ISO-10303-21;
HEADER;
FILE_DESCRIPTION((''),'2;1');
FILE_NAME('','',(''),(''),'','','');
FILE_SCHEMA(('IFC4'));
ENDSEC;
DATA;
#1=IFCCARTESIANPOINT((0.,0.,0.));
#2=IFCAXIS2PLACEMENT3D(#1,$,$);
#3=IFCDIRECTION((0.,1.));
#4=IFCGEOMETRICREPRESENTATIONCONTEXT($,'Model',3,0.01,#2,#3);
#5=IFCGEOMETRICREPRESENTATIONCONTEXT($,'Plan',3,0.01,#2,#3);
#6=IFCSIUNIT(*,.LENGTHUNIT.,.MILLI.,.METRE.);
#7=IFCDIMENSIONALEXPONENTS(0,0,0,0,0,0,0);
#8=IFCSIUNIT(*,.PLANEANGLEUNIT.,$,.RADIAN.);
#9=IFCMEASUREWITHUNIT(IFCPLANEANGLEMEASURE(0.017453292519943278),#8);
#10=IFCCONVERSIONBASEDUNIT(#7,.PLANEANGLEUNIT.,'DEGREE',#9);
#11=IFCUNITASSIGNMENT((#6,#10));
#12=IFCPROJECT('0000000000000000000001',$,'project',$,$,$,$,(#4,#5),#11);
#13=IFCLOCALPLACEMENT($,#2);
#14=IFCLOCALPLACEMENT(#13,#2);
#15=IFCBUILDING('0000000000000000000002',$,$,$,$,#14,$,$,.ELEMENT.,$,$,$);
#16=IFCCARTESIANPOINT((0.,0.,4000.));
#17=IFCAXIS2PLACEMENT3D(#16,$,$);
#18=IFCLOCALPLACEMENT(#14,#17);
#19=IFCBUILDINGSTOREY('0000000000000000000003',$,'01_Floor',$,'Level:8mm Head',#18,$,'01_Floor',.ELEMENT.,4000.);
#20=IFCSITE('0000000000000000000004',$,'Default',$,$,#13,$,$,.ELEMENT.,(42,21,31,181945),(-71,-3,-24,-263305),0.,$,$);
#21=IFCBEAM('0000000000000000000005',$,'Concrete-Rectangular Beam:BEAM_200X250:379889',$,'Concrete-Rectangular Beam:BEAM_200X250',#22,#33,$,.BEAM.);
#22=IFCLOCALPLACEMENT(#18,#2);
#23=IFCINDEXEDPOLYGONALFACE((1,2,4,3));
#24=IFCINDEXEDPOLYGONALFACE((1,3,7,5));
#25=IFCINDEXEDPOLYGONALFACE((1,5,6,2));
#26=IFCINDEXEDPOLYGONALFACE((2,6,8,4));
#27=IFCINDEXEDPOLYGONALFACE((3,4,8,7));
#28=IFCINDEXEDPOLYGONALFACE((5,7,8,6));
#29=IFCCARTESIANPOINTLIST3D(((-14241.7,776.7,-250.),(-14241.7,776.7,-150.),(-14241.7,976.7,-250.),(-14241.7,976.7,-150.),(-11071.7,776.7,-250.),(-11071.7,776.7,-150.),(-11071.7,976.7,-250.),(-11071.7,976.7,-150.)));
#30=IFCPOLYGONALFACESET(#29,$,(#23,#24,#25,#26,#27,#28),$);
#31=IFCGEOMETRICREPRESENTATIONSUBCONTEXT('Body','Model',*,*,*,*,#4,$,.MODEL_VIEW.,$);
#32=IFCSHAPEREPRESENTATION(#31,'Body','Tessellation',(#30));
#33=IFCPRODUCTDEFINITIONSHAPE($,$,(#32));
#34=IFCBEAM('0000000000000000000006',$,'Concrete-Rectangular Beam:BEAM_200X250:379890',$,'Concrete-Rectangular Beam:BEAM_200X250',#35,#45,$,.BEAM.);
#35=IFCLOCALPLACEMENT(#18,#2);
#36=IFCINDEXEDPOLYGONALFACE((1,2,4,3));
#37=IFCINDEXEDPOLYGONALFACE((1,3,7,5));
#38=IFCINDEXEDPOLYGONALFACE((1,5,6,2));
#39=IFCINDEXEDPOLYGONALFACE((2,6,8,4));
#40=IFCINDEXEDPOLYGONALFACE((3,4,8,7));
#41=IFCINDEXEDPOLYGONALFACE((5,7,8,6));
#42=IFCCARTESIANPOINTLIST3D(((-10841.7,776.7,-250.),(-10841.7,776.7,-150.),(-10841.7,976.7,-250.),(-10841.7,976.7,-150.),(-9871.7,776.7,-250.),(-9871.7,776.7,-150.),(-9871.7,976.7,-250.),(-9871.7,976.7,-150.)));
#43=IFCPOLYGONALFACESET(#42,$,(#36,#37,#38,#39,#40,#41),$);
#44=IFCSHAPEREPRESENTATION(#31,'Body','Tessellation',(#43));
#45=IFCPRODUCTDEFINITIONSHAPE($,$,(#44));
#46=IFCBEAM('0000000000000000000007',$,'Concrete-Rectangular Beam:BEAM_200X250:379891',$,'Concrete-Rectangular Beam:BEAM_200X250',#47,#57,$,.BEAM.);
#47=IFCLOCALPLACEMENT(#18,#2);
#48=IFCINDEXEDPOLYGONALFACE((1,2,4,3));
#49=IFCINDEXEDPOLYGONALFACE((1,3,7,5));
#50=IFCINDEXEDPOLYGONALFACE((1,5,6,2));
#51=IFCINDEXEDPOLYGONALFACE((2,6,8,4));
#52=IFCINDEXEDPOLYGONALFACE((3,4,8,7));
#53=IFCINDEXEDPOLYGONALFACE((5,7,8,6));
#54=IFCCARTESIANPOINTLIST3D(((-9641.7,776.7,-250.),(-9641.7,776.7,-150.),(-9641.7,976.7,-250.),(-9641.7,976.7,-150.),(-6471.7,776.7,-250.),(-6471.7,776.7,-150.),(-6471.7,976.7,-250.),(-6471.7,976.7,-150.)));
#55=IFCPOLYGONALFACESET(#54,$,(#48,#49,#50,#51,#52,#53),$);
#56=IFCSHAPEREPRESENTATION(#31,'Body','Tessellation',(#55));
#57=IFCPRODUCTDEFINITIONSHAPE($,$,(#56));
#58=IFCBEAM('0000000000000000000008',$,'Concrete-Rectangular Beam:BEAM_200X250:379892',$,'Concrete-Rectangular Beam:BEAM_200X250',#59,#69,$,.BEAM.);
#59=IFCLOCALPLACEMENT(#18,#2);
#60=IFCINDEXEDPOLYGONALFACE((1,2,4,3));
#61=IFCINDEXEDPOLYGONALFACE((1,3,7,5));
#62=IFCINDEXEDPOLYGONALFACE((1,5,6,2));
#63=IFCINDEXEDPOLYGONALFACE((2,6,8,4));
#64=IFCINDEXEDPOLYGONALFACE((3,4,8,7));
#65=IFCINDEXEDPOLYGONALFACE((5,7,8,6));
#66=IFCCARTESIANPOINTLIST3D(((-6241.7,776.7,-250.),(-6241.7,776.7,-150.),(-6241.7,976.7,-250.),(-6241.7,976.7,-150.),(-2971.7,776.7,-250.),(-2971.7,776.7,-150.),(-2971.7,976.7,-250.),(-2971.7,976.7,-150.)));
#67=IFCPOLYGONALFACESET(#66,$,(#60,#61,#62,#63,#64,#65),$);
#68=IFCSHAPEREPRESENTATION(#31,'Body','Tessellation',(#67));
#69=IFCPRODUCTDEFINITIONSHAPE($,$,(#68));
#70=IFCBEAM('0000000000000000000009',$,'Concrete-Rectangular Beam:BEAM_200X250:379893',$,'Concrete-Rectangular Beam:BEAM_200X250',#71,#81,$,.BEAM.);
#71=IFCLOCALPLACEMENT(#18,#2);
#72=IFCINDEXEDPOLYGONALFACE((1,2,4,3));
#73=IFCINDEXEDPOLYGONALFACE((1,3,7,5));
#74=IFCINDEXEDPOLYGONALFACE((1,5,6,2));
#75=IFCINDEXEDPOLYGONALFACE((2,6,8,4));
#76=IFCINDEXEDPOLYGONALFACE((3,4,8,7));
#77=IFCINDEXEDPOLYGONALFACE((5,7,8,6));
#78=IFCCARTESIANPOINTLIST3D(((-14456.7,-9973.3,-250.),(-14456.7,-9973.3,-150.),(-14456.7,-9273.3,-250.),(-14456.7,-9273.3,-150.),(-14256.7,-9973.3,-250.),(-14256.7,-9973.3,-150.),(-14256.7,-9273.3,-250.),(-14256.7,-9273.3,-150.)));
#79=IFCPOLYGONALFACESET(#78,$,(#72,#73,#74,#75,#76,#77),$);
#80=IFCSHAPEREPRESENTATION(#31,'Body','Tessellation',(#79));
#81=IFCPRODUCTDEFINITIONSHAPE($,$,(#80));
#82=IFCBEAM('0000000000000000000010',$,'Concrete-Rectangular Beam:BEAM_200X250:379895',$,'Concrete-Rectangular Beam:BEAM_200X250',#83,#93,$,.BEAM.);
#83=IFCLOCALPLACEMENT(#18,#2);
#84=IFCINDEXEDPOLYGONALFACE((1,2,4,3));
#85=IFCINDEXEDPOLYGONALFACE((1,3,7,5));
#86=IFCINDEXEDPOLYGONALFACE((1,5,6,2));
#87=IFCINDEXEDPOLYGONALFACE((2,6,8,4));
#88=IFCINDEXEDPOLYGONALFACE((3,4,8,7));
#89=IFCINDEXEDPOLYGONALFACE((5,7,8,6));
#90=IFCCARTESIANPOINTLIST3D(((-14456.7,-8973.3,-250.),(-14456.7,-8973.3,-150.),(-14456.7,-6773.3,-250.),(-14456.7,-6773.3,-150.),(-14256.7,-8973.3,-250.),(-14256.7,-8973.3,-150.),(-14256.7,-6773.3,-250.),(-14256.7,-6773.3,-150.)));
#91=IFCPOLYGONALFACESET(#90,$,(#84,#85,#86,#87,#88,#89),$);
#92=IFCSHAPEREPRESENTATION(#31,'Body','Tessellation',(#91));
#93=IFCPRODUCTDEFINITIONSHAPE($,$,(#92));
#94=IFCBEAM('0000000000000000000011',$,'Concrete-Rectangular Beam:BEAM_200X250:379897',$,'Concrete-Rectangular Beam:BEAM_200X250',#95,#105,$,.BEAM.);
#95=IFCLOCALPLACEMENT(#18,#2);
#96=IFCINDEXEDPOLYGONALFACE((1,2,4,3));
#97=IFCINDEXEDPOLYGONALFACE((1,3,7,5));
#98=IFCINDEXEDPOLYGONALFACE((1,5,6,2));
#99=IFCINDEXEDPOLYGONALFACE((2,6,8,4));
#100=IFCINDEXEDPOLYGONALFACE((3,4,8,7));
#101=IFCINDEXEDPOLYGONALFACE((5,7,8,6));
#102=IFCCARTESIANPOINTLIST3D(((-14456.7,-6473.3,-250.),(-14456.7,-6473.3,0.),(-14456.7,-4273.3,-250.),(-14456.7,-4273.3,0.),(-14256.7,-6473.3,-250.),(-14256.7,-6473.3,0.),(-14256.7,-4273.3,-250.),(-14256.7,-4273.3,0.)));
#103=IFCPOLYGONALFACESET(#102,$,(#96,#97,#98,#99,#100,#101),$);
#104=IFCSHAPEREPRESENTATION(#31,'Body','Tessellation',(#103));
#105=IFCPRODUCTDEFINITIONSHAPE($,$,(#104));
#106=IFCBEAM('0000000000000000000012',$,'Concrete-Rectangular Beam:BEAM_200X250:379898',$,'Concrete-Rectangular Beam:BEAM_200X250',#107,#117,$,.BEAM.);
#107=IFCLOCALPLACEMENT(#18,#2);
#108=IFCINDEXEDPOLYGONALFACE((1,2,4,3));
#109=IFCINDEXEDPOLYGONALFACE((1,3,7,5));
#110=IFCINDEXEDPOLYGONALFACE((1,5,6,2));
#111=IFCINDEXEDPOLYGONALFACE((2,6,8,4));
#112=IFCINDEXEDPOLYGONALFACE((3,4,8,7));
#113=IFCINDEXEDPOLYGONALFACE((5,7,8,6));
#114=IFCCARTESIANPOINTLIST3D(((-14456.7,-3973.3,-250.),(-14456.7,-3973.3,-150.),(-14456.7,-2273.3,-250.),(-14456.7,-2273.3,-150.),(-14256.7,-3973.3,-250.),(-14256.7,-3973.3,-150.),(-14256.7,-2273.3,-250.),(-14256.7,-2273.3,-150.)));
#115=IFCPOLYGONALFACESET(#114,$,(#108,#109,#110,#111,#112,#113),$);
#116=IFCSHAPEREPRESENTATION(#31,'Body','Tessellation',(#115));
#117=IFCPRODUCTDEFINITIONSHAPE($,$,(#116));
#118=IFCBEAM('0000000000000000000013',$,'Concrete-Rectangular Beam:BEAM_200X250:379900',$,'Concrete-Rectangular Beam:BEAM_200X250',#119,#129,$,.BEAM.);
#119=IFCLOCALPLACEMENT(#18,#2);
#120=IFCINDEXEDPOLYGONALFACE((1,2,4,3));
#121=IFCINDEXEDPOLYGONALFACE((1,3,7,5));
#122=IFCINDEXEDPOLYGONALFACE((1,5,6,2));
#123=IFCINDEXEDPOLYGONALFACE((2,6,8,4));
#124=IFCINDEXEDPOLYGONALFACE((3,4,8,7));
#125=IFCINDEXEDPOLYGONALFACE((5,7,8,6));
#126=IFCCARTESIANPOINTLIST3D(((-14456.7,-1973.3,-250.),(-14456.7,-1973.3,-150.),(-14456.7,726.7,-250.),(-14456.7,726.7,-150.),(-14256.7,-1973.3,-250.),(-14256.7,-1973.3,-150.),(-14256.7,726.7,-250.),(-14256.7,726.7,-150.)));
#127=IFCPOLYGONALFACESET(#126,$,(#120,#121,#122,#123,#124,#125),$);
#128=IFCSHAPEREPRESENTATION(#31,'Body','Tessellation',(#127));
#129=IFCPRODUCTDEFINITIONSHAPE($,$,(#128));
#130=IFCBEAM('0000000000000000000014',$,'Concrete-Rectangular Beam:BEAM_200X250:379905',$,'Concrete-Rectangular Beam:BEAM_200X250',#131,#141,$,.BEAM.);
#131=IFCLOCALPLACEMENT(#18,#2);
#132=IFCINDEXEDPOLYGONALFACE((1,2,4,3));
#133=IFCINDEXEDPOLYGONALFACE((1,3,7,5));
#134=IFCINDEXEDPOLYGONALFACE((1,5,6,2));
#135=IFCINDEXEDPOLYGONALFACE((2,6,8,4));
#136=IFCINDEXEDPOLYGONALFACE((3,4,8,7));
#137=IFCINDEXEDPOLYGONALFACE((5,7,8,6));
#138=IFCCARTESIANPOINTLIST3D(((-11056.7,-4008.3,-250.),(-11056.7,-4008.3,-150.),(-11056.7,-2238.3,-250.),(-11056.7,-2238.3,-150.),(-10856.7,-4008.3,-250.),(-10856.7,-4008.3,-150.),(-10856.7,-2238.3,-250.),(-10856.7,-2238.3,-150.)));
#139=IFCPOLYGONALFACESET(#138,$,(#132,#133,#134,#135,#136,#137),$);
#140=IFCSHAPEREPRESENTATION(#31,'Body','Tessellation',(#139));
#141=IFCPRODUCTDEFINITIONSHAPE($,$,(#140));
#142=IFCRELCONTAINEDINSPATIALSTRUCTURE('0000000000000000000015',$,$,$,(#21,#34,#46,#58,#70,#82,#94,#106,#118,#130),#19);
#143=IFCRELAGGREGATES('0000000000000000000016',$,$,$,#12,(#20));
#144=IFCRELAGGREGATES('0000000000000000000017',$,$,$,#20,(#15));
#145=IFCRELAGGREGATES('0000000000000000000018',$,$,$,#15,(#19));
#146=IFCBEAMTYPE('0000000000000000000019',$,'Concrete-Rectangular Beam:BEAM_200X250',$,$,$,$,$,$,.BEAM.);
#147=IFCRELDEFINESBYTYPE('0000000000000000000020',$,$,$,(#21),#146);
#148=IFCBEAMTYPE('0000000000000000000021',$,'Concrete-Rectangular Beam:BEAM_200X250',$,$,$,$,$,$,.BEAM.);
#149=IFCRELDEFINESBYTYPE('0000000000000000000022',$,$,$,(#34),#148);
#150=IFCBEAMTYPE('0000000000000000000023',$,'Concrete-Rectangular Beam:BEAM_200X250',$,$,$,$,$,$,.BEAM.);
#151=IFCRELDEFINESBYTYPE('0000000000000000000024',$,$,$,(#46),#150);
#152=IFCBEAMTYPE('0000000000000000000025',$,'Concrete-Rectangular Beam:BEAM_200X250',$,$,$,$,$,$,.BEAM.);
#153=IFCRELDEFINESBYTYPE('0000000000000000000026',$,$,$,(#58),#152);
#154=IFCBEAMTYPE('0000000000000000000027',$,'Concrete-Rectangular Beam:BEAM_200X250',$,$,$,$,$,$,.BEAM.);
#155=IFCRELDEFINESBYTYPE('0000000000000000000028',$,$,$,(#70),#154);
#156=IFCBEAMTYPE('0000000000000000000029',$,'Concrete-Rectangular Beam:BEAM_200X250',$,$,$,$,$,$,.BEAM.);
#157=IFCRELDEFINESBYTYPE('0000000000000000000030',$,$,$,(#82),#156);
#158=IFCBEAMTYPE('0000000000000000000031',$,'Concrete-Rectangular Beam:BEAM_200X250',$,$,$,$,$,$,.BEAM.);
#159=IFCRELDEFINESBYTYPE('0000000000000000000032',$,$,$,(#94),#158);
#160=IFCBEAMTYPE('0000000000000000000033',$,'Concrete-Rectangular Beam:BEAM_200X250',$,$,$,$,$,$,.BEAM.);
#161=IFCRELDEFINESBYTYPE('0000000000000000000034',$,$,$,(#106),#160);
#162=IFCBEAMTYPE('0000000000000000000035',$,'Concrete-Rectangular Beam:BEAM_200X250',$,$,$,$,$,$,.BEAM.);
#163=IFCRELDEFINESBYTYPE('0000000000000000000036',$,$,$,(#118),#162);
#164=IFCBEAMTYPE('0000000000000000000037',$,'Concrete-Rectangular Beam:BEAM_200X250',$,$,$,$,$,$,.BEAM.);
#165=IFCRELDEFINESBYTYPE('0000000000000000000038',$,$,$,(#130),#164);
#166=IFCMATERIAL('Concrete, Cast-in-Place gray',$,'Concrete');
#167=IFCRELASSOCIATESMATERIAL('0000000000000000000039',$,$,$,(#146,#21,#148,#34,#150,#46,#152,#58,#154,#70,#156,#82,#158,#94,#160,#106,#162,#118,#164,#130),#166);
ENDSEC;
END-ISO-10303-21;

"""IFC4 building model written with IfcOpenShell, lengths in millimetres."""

from ifc_helpers import new_model, entity, si_unit, converted_unit, direction, frame, origin, place, context, subcontext, project, spatial, indexed_curve, outline, extrude, source, transform, mapped, material, type_object, type_shapes, element, save


model = new_model("IFC4")

# Units and contexts
model_context = context("Model", 3, precision=0.01, world=origin(), true_north=direction((0.0, 1.0)))
plan_context = context("Plan", 3, precision=0.01, world=origin(), true_north=direction((0.0, 1.0)))
body_context = subcontext(model_context, "Body", "Model", "MODEL_VIEW")
ifc_project = project(units=[si_unit("LENGTHUNIT", "METRE", prefix="MILLI"), converted_unit("PLANEANGLEUNIT", "DEGREE", entity("IfcPlaneAngleMeasure", 0.017453292519943278), si_unit("PLANEANGLEUNIT", "RADIAN"), dimensions=[0, 0, 0, 0, 0, 0, 0])], contexts=[model_context, plan_context])

# Site, building, storey
site_placement = place(None, origin())
site = spatial("IfcSite", under=ifc_project, at=site_placement, Name="Default", CompositionType="ELEMENT", RefLatitude=(42, 21, 31, 181945), RefLongitude=(-71, -3, -24, -263305), RefElevation=0.0)
building_placement = place(site_placement, origin())
building = spatial("IfcBuilding", under=site, at=building_placement, CompositionType="ELEMENT")
storey_placement = place(building_placement, frame((0.0, 0.0, 4000.0)))
storey = spatial("IfcBuildingStorey", under=building, at=storey_placement, Name="01_Floor", ObjectType="Level:8mm Head", LongName="01_Floor", CompositionType="ELEMENT", Elevation=4000.0)

# Beams
ifc_material = material(Name="Concrete, Cast-in-Place gray", Category="Concrete")
beam_type_1 = type_object("IfcBeamType", Name="Concrete-Rectangular Beam:BEAM_200X250", PredefinedType="BEAM", material=ifc_material)
shared_shape_1 = source(origin(), body_context, "Body", "SweptSolid", [
    extrude(outline(indexed_curve([(-50.0, -100.0), (50.0, -100.0), (50.0, 100.0), (-50.0, 100.0), (-50.0, -100.0)], self_intersect=False)), frame((-14241.7, 876.7, 3800.0), z_axis=(1.0, 0.0, 0.0), x_axis=(0.0, 0.0, -1.0)), (0.0, 0.0, 1.0), 3170.0),
])
type_shapes(beam_type_1, [shared_shape_1])
beam_1_placement = place(storey_placement, frame((0.0, 0.0, -4000.0)))
element("IfcBeam", 1, at=beam_1_placement, inside=storey, type_object=beam_type_1, material=ifc_material, Name="Concrete-Rectangular Beam:BEAM_200X250:379889", ObjectType="Concrete-Rectangular Beam:BEAM_200X250", PredefinedType="BEAM", context=body_context, shape_type="MappedRepresentation", body=[
    mapped(shared_shape_1, transform((0.0, 0.0, 0.0), scale=1.0)),
])
beam_type_2 = type_object("IfcBeamType", Name="Concrete-Rectangular Beam:BEAM_200X250", PredefinedType="BEAM", material=ifc_material)
shared_shape_2 = source(origin(), body_context, "Body", "SweptSolid", [
    extrude(outline(indexed_curve([(-50.0, -100.0), (50.0, -100.0), (50.0, 100.0), (-50.0, 100.0), (-50.0, -100.0)], self_intersect=False)), frame((-10841.7, 876.7, 3800.0), z_axis=(1.0, 0.0, 0.0), x_axis=(0.0, 0.0, -1.0)), (0.0, 0.0, 1.0), 970.0),
])
type_shapes(beam_type_2, [shared_shape_2])
beam_2_placement = place(storey_placement, frame((0.0, 0.0, -4000.0)))
element("IfcBeam", 2, at=beam_2_placement, inside=storey, type_object=beam_type_2, material=ifc_material, Name="Concrete-Rectangular Beam:BEAM_200X250:379890", ObjectType="Concrete-Rectangular Beam:BEAM_200X250", PredefinedType="BEAM", context=body_context, shape_type="MappedRepresentation", body=[
    mapped(shared_shape_2, transform((0.0, 0.0, 0.0), scale=1.0)),
])
beam_type_3 = type_object("IfcBeamType", Name="Concrete-Rectangular Beam:BEAM_200X250", PredefinedType="BEAM", material=ifc_material)
shared_shape_3 = source(origin(), body_context, "Body", "SweptSolid", [
    extrude(outline(indexed_curve([(-50.0, -100.0), (50.0, -100.0), (50.0, 100.0), (-50.0, 100.0), (-50.0, -100.0)], self_intersect=False)), frame((-9641.7, 876.7, 3800.0), z_axis=(1.0, 0.0, 0.0), x_axis=(0.0, 0.0, -1.0)), (0.0, 0.0, 1.0), 3170.0),
])
type_shapes(beam_type_3, [shared_shape_3])
beam_3_placement = place(storey_placement, frame((0.0, 0.0, -4000.0)))
element("IfcBeam", 3, at=beam_3_placement, inside=storey, type_object=beam_type_3, material=ifc_material, Name="Concrete-Rectangular Beam:BEAM_200X250:379891", ObjectType="Concrete-Rectangular Beam:BEAM_200X250", PredefinedType="BEAM", context=body_context, shape_type="MappedRepresentation", body=[
    mapped(shared_shape_3, transform((0.0, 0.0, 0.0), scale=1.0)),
])
beam_type_4 = type_object("IfcBeamType", Name="Concrete-Rectangular Beam:BEAM_200X250", PredefinedType="BEAM", material=ifc_material)
shared_shape_4 = source(origin(), body_context, "Body", "SweptSolid", [
    extrude(outline(indexed_curve([(-50.0, -100.0), (50.0, -100.0), (50.0, 100.0), (-50.0, 100.0), (-50.0, -100.0)], self_intersect=False)), frame((-6241.7, 876.7, 3800.0), z_axis=(1.0, 0.0, 0.0), x_axis=(0.0, 0.0, -1.0)), (0.0, 0.0, 1.0), 3270.0),
])
type_shapes(beam_type_4, [shared_shape_4])
beam_4_placement = place(storey_placement, frame((0.0, 0.0, -4000.0)))
element("IfcBeam", 4, at=beam_4_placement, inside=storey, type_object=beam_type_4, material=ifc_material, Name="Concrete-Rectangular Beam:BEAM_200X250:379892", ObjectType="Concrete-Rectangular Beam:BEAM_200X250", PredefinedType="BEAM", context=body_context, shape_type="MappedRepresentation", body=[
    mapped(shared_shape_4, transform((0.0, 0.0, 0.0), scale=1.0)),
])
beam_type_5 = type_object("IfcBeamType", Name="Concrete-Rectangular Beam:BEAM_200X250", PredefinedType="BEAM", material=ifc_material)
shared_shape_5 = source(origin(), body_context, "Body", "SweptSolid", [
    extrude(outline(indexed_curve([(-100.0, -50.0), (100.0, -50.0), (100.0, 50.0), (-100.0, 50.0), (-100.0, -50.0)], self_intersect=False)), frame((-14356.7, -9973.3, 3800.0), z_axis=(0.0, 1.0, 0.0), x_axis=(-1.0, 0.0, 0.0)), (0.0, 0.0, 1.0), 700.0),
])
type_shapes(beam_type_5, [shared_shape_5])
beam_5_placement = place(storey_placement, frame((0.0, 0.0, -4000.0)))
element("IfcBeam", 5, at=beam_5_placement, inside=storey, type_object=beam_type_5, material=ifc_material, Name="Concrete-Rectangular Beam:BEAM_200X250:379893", ObjectType="Concrete-Rectangular Beam:BEAM_200X250", PredefinedType="BEAM", context=body_context, shape_type="MappedRepresentation", body=[
    mapped(shared_shape_5, transform((0.0, 0.0, 0.0), scale=1.0)),
])
beam_type_6 = type_object("IfcBeamType", Name="Concrete-Rectangular Beam:BEAM_200X250", PredefinedType="BEAM", material=ifc_material)
shared_shape_6 = source(origin(), body_context, "Body", "SweptSolid", [
    extrude(outline(indexed_curve([(-100.0, -50.0), (100.0, -50.0), (100.0, 50.0), (-100.0, 50.0), (-100.0, -50.0)], self_intersect=False)), frame((-14356.7, -8973.3, 3800.0), z_axis=(0.0, 1.0, 0.0), x_axis=(-1.0, 0.0, 0.0)), (0.0, 0.0, 1.0), 2200.0),
])
type_shapes(beam_type_6, [shared_shape_6])
beam_6_placement = place(storey_placement, frame((0.0, 0.0, -4000.0)))
element("IfcBeam", 6, at=beam_6_placement, inside=storey, type_object=beam_type_6, material=ifc_material, Name="Concrete-Rectangular Beam:BEAM_200X250:379895", ObjectType="Concrete-Rectangular Beam:BEAM_200X250", PredefinedType="BEAM", context=body_context, shape_type="MappedRepresentation", body=[
    mapped(shared_shape_6, transform((0.0, 0.0, 0.0), scale=1.0)),
])
beam_type_7 = type_object("IfcBeamType", Name="Concrete-Rectangular Beam:BEAM_200X250", PredefinedType="BEAM", material=ifc_material)
shared_shape_7 = source(origin(), body_context, "Body", "SweptSolid", [
    extrude(outline(indexed_curve([(-100.0, -125.0), (100.0, -125.0), (100.0, 125.0), (-100.0, 125.0), (-100.0, -125.0)], self_intersect=False)), frame((-14356.7, -6473.3, 3875.0), z_axis=(0.0, 1.0, 0.0), x_axis=(-1.0, 0.0, 0.0)), (0.0, 0.0, 1.0), 2200.0),
])
type_shapes(beam_type_7, [shared_shape_7])
beam_7_placement = place(storey_placement, frame((0.0, 0.0, -4000.0)))
element("IfcBeam", 7, at=beam_7_placement, inside=storey, type_object=beam_type_7, material=ifc_material, Name="Concrete-Rectangular Beam:BEAM_200X250:379897", ObjectType="Concrete-Rectangular Beam:BEAM_200X250", PredefinedType="BEAM", context=body_context, shape_type="MappedRepresentation", body=[
    mapped(shared_shape_7, transform((0.0, 0.0, 0.0), scale=1.0)),
])
beam_type_8 = type_object("IfcBeamType", Name="Concrete-Rectangular Beam:BEAM_200X250", PredefinedType="BEAM", material=ifc_material)
shared_shape_8 = source(origin(), body_context, "Body", "SweptSolid", [
    extrude(outline(indexed_curve([(-100.0, -50.0), (100.0, -50.0), (100.0, 50.0), (-100.0, 50.0), (-100.0, -50.0)], self_intersect=False)), frame((-14356.7, -3973.3, 3800.0), z_axis=(0.0, 1.0, 0.0), x_axis=(-1.0, 0.0, 0.0)), (0.0, 0.0, 1.0), 1700.0),
])
type_shapes(beam_type_8, [shared_shape_8])
beam_8_placement = place(storey_placement, frame((0.0, 0.0, -4000.0)))
element("IfcBeam", 8, at=beam_8_placement, inside=storey, type_object=beam_type_8, material=ifc_material, Name="Concrete-Rectangular Beam:BEAM_200X250:379898", ObjectType="Concrete-Rectangular Beam:BEAM_200X250", PredefinedType="BEAM", context=body_context, shape_type="MappedRepresentation", body=[
    mapped(shared_shape_8, transform((0.0, 0.0, 0.0), scale=1.0)),
])
beam_type_9 = type_object("IfcBeamType", Name="Concrete-Rectangular Beam:BEAM_200X250", PredefinedType="BEAM", material=ifc_material)
shared_shape_9 = source(origin(), body_context, "Body", "SweptSolid", [
    extrude(outline(indexed_curve([(-100.0, -50.0), (100.0, -50.0), (100.0, 50.0), (-100.0, 50.0), (-100.0, -50.0)], self_intersect=False)), frame((-14356.7, -1973.3, 3800.0), z_axis=(0.0, 1.0, 0.0), x_axis=(-1.0, 0.0, 0.0)), (0.0, 0.0, 1.0), 2700.0),
])
type_shapes(beam_type_9, [shared_shape_9])
beam_9_placement = place(storey_placement, frame((0.0, 0.0, -4000.0)))
element("IfcBeam", 9, at=beam_9_placement, inside=storey, type_object=beam_type_9, material=ifc_material, Name="Concrete-Rectangular Beam:BEAM_200X250:379900", ObjectType="Concrete-Rectangular Beam:BEAM_200X250", PredefinedType="BEAM", context=body_context, shape_type="MappedRepresentation", body=[
    mapped(shared_shape_9, transform((0.0, 0.0, 0.0), scale=1.0)),
])
beam_type_10 = type_object("IfcBeamType", Name="Concrete-Rectangular Beam:BEAM_200X250", PredefinedType="BEAM", material=ifc_material)
shared_shape_10 = source(origin(), body_context, "Body", "SweptSolid", [
    extrude(outline(indexed_curve([(-100.0, -50.0), (100.0, -50.0), (100.0, 50.0), (-100.0, 50.0), (-100.0, -50.0)], self_intersect=False)), frame((-10956.7, -4008.3, 3800.0), z_axis=(0.0, 1.0, 0.0), x_axis=(-1.0, 0.0, 0.0)), (0.0, 0.0, 1.0), 1770.0),
])
type_shapes(beam_type_10, [shared_shape_10])
beam_10_placement = place(storey_placement, frame((0.0, 0.0, -4000.0)))
element("IfcBeam", 10, at=beam_10_placement, inside=storey, type_object=beam_type_10, material=ifc_material, Name="Concrete-Rectangular Beam:BEAM_200X250:379905", ObjectType="Concrete-Rectangular Beam:BEAM_200X250", PredefinedType="BEAM", context=body_context, shape_type="MappedRepresentation", body=[
    mapped(shared_shape_10, transform((0.0, 0.0, 0.0), scale=1.0)),
])

save(model, "model.ifc")
